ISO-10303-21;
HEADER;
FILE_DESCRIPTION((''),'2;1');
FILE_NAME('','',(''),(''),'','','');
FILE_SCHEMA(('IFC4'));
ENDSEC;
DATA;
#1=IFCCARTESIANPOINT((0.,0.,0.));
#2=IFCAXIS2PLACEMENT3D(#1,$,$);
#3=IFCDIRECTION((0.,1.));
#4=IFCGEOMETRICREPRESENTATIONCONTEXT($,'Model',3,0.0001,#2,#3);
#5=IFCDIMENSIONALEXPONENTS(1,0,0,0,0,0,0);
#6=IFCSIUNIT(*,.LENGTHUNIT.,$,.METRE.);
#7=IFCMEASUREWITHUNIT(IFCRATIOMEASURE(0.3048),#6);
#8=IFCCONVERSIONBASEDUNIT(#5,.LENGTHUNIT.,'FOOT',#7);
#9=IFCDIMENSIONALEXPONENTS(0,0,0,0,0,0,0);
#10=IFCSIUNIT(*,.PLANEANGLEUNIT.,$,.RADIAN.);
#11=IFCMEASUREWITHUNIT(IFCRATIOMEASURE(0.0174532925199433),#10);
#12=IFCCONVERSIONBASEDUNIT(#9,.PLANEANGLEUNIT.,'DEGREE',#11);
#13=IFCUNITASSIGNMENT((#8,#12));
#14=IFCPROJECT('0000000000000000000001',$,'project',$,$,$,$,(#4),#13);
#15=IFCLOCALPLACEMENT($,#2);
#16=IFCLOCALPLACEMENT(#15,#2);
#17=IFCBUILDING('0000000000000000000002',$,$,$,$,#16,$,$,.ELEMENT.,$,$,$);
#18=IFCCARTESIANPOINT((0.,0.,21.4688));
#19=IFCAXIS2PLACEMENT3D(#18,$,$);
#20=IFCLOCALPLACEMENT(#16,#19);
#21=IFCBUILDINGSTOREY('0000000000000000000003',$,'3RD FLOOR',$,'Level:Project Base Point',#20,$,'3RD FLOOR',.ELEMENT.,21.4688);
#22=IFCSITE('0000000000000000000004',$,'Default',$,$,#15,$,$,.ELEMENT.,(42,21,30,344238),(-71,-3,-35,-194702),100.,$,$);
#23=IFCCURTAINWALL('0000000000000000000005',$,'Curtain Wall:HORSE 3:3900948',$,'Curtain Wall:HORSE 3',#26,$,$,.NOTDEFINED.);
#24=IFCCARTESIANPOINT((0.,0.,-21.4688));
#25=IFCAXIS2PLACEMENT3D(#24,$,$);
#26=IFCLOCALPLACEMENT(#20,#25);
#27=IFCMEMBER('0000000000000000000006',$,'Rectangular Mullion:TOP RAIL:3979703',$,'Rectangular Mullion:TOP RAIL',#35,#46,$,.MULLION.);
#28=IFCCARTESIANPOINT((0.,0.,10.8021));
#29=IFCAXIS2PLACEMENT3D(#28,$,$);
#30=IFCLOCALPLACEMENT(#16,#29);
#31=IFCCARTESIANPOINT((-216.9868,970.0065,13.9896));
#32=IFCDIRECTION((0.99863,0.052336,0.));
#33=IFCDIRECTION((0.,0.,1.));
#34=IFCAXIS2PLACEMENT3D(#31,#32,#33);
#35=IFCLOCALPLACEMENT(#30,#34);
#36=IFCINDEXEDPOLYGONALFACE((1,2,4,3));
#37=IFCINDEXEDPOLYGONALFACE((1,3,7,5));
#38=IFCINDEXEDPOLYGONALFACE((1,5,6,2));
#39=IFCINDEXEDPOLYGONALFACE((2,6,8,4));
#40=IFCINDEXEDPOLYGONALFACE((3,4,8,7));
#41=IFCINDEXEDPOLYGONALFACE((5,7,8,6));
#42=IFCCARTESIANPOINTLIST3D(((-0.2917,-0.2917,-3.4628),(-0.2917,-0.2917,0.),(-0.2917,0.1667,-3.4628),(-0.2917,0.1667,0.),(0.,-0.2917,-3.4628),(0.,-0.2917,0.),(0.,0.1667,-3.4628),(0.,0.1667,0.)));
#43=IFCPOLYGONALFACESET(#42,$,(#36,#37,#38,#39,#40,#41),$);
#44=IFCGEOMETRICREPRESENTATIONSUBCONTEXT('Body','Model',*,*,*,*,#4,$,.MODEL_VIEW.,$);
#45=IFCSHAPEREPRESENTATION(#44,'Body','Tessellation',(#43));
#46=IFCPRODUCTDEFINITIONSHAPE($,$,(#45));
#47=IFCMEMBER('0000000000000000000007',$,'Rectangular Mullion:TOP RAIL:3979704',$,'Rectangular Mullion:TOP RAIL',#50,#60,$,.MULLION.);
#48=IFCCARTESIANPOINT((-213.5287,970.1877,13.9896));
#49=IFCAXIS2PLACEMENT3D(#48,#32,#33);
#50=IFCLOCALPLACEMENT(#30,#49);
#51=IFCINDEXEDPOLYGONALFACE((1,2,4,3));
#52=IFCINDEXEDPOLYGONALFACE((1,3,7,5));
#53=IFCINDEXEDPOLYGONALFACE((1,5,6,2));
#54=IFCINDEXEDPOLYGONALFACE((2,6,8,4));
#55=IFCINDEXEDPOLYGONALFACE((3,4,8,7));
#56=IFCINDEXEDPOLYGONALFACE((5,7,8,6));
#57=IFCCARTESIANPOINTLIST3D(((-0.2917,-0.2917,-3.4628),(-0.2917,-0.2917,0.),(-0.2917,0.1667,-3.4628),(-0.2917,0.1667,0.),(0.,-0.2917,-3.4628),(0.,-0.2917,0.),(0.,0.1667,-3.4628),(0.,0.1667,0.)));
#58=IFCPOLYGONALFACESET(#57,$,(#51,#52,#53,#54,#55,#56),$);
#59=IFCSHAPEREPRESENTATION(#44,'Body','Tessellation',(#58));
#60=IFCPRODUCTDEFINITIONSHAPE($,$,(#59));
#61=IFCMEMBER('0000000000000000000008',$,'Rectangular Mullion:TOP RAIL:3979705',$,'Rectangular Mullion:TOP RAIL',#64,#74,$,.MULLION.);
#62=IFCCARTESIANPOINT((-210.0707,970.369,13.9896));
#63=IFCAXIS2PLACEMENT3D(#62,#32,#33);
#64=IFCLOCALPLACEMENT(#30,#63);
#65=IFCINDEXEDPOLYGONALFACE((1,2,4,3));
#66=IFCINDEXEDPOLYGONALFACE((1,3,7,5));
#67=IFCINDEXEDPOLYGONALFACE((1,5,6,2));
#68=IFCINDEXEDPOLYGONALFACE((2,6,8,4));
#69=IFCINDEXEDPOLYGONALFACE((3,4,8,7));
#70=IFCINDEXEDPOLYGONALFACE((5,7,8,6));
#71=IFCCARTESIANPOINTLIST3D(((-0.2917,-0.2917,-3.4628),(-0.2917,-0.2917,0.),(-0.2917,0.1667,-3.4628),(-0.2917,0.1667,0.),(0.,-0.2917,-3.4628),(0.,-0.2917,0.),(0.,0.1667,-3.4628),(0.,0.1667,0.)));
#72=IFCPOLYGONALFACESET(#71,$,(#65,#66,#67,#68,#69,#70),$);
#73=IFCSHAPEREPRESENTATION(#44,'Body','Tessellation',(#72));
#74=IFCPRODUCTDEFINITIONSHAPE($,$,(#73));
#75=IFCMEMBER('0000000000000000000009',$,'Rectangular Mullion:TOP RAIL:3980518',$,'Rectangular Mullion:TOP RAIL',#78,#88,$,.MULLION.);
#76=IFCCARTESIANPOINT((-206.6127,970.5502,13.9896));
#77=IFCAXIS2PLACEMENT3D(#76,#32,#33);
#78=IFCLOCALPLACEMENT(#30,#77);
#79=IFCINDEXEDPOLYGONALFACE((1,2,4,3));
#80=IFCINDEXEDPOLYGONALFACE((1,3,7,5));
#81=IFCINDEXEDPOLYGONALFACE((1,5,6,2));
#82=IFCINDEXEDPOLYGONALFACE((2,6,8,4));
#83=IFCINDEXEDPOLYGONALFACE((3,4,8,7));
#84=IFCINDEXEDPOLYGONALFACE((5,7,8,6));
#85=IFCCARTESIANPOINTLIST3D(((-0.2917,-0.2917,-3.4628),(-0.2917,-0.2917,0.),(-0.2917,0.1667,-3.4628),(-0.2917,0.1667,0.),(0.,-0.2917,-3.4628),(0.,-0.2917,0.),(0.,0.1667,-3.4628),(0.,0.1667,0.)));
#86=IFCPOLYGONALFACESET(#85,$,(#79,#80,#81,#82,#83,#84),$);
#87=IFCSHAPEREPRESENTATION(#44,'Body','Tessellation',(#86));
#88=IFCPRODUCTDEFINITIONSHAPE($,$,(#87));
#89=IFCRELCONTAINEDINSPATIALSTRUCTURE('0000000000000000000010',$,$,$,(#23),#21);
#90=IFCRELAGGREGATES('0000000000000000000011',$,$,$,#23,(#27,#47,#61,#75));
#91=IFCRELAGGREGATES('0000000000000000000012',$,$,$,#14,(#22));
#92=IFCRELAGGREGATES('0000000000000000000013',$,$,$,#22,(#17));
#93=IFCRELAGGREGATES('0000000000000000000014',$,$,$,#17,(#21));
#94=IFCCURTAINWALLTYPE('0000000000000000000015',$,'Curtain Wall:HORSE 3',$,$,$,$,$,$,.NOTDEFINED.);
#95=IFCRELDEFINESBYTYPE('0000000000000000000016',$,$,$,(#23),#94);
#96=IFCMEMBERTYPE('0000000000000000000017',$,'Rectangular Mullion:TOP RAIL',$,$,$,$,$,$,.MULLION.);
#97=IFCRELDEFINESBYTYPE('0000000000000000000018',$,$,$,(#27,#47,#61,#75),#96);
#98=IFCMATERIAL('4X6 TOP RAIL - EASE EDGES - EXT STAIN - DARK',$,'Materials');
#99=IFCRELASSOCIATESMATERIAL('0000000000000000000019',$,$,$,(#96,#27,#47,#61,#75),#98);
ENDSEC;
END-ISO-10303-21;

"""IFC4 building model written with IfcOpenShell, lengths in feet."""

from ifc_helpers import new_model, entity, si_unit, converted_unit, direction, frame, origin, origin_2d_with_axis, place, context, subcontext, project, spatial, rectangle, extrude, source, transform, mapped, material, material_profile, profile_set, profile_usage, type_object, type_shapes, element, aggregate, save


model = new_model("IFC4")

# Units and contexts
model_context = context("Model", 3, precision=0.0001, world=origin(), true_north=direction((0.0, 1.0)))
body_context = subcontext(model_context, "Body", "Model", "MODEL_VIEW")
ifc_project = project(units=[converted_unit("LENGTHUNIT", "FOOT", entity("IfcRatioMeasure", 0.3048), si_unit("LENGTHUNIT", "METRE"), dimensions=[1, 0, 0, 0, 0, 0, 0]), converted_unit("PLANEANGLEUNIT", "DEGREE", entity("IfcRatioMeasure", 0.0174532925199433), si_unit("PLANEANGLEUNIT", "RADIAN"), dimensions=[0, 0, 0, 0, 0, 0, 0])], contexts=[model_context])

# Site, building, storey
site_placement = place(None, origin())
site = spatial("IfcSite", under=ifc_project, at=site_placement, Name="Default", CompositionType="ELEMENT", RefLatitude=(42, 21, 30, 344238), RefLongitude=(-71, -3, -35, -194702), RefElevation=100.0)
building_placement = place(site_placement, origin())
building = spatial("IfcBuilding", under=site, at=building_placement, CompositionType="ELEMENT")
storey_placement = place(building_placement, frame((0.0, 0.0, 21.4688)))
storey = spatial("IfcBuildingStorey", under=building, at=storey_placement, Name="3RD FLOOR", ObjectType="Level:Project Base Point", LongName="3RD FLOOR", CompositionType="ELEMENT", Elevation=21.4688)

# Curtain wall
curtain_wall_type_1 = type_object("IfcCurtainWallType", Name="Curtain Wall:HORSE 3", PredefinedType="NOTDEFINED")
curtain_wall_1_placement = place(storey_placement, frame((0.0, 0.0, -21.4688)))
curtain_wall_1 = element("IfcCurtainWall", 1, at=curtain_wall_1_placement, inside=storey, type_object=curtain_wall_type_1, Name="Curtain Wall:HORSE 3:3900948", ObjectType="Curtain Wall:HORSE 3", PredefinedType="NOTDEFINED")

# Members
ifc_material_1 = material(Name="4X6 TOP RAIL - EASE EDGES - EXT STAIN - DARK", Category="Materials")
ifc_material_profile_1 = material_profile(ifc_material_1, rectangle(XDim=0.4583, YDim=0.2917, at=origin_2d_with_axis()), Name="TOP RAIL")
ifc_profile_set_1 = profile_set([ifc_material_profile_1], Name="TOP RAIL")
placement = place(building_placement, frame((0.0, 0.0, 10.8021)))
ifc_profile_usage_1 = profile_usage(ifc_profile_set_1)
member_type_1 = type_object("IfcMemberType", Name="Rectangular Mullion:TOP RAIL", PredefinedType="MULLION", material=ifc_profile_set_1)
shared_shape_1 = source(origin(), body_context, "Body", "SweptSolid", [
    extrude(rectangle(XDim=0.4583, YDim=0.2917, at=origin_2d_with_axis()), frame((-0.1458, -0.0625, -3.4628), z_axis=(0.0, 0.0, 1.0), x_axis=(0.0, -1.0, 0.0)), (0.0, 0.0, 1.0), 3.4628),
])
type_shapes(member_type_1, [shared_shape_1])
member_1_placement = place(placement, frame((-216.9868, 970.0065, 13.9896), z_axis=(0.99863, 0.052336, 0.0), x_axis=(0.0, 0.0, 1.0)))
member_1 = element("IfcMember", 2, at=member_1_placement, type_object=member_type_1, material=ifc_profile_usage_1, Name="Rectangular Mullion:TOP RAIL:3979703", ObjectType="Rectangular Mullion:TOP RAIL", PredefinedType="MULLION", context=body_context, shape_type="MappedRepresentation", body=[
    mapped(shared_shape_1, transform((0.0, 0.0, 0.0), scale=1.0)),
])
ifc_profile_usage_2 = profile_usage(ifc_profile_set_1)
member_2_placement = place(placement, frame((-213.5287, 970.1877, 13.9896), z_axis=(0.99863, 0.052336, 0.0), x_axis=(0.0, 0.0, 1.0)))
member_2 = element("IfcMember", 3, at=member_2_placement, type_object=member_type_1, material=ifc_profile_usage_2, Name="Rectangular Mullion:TOP RAIL:3979704", ObjectType="Rectangular Mullion:TOP RAIL", PredefinedType="MULLION", context=body_context, shape_type="MappedRepresentation", body=[
    mapped(shared_shape_1, transform((0.0, 0.0, 0.0), scale=1.0)),
])
ifc_profile_usage_3 = profile_usage(ifc_profile_set_1)
member_3_placement = place(placement, frame((-210.0707, 970.369, 13.9896), z_axis=(0.99863, 0.052336, 0.0), x_axis=(0.0, 0.0, 1.0)))
member_3 = element("IfcMember", 4, at=member_3_placement, type_object=member_type_1, material=ifc_profile_usage_3, Name="Rectangular Mullion:TOP RAIL:3979705", ObjectType="Rectangular Mullion:TOP RAIL", PredefinedType="MULLION", context=body_context, shape_type="MappedRepresentation", body=[
    mapped(shared_shape_1, transform((0.0, 0.0, 0.0), scale=1.0)),
])
ifc_profile_usage_4 = profile_usage(ifc_profile_set_1)
member_4_placement = place(placement, frame((-206.6127, 970.5502, 13.9896), z_axis=(0.99863, 0.052336, 0.0), x_axis=(0.0, 0.0, 1.0)))
member_4 = element("IfcMember", 5, at=member_4_placement, type_object=member_type_1, material=ifc_profile_usage_4, Name="Rectangular Mullion:TOP RAIL:3980518", ObjectType="Rectangular Mullion:TOP RAIL", PredefinedType="MULLION", context=body_context, shape_type="MappedRepresentation", body=[
    mapped(shared_shape_1, transform((0.0, 0.0, 0.0), scale=1.0)),
])

aggregate(curtain_wall_1, [member_1, member_2, member_3, member_4])

save(model, "model.ifc")
